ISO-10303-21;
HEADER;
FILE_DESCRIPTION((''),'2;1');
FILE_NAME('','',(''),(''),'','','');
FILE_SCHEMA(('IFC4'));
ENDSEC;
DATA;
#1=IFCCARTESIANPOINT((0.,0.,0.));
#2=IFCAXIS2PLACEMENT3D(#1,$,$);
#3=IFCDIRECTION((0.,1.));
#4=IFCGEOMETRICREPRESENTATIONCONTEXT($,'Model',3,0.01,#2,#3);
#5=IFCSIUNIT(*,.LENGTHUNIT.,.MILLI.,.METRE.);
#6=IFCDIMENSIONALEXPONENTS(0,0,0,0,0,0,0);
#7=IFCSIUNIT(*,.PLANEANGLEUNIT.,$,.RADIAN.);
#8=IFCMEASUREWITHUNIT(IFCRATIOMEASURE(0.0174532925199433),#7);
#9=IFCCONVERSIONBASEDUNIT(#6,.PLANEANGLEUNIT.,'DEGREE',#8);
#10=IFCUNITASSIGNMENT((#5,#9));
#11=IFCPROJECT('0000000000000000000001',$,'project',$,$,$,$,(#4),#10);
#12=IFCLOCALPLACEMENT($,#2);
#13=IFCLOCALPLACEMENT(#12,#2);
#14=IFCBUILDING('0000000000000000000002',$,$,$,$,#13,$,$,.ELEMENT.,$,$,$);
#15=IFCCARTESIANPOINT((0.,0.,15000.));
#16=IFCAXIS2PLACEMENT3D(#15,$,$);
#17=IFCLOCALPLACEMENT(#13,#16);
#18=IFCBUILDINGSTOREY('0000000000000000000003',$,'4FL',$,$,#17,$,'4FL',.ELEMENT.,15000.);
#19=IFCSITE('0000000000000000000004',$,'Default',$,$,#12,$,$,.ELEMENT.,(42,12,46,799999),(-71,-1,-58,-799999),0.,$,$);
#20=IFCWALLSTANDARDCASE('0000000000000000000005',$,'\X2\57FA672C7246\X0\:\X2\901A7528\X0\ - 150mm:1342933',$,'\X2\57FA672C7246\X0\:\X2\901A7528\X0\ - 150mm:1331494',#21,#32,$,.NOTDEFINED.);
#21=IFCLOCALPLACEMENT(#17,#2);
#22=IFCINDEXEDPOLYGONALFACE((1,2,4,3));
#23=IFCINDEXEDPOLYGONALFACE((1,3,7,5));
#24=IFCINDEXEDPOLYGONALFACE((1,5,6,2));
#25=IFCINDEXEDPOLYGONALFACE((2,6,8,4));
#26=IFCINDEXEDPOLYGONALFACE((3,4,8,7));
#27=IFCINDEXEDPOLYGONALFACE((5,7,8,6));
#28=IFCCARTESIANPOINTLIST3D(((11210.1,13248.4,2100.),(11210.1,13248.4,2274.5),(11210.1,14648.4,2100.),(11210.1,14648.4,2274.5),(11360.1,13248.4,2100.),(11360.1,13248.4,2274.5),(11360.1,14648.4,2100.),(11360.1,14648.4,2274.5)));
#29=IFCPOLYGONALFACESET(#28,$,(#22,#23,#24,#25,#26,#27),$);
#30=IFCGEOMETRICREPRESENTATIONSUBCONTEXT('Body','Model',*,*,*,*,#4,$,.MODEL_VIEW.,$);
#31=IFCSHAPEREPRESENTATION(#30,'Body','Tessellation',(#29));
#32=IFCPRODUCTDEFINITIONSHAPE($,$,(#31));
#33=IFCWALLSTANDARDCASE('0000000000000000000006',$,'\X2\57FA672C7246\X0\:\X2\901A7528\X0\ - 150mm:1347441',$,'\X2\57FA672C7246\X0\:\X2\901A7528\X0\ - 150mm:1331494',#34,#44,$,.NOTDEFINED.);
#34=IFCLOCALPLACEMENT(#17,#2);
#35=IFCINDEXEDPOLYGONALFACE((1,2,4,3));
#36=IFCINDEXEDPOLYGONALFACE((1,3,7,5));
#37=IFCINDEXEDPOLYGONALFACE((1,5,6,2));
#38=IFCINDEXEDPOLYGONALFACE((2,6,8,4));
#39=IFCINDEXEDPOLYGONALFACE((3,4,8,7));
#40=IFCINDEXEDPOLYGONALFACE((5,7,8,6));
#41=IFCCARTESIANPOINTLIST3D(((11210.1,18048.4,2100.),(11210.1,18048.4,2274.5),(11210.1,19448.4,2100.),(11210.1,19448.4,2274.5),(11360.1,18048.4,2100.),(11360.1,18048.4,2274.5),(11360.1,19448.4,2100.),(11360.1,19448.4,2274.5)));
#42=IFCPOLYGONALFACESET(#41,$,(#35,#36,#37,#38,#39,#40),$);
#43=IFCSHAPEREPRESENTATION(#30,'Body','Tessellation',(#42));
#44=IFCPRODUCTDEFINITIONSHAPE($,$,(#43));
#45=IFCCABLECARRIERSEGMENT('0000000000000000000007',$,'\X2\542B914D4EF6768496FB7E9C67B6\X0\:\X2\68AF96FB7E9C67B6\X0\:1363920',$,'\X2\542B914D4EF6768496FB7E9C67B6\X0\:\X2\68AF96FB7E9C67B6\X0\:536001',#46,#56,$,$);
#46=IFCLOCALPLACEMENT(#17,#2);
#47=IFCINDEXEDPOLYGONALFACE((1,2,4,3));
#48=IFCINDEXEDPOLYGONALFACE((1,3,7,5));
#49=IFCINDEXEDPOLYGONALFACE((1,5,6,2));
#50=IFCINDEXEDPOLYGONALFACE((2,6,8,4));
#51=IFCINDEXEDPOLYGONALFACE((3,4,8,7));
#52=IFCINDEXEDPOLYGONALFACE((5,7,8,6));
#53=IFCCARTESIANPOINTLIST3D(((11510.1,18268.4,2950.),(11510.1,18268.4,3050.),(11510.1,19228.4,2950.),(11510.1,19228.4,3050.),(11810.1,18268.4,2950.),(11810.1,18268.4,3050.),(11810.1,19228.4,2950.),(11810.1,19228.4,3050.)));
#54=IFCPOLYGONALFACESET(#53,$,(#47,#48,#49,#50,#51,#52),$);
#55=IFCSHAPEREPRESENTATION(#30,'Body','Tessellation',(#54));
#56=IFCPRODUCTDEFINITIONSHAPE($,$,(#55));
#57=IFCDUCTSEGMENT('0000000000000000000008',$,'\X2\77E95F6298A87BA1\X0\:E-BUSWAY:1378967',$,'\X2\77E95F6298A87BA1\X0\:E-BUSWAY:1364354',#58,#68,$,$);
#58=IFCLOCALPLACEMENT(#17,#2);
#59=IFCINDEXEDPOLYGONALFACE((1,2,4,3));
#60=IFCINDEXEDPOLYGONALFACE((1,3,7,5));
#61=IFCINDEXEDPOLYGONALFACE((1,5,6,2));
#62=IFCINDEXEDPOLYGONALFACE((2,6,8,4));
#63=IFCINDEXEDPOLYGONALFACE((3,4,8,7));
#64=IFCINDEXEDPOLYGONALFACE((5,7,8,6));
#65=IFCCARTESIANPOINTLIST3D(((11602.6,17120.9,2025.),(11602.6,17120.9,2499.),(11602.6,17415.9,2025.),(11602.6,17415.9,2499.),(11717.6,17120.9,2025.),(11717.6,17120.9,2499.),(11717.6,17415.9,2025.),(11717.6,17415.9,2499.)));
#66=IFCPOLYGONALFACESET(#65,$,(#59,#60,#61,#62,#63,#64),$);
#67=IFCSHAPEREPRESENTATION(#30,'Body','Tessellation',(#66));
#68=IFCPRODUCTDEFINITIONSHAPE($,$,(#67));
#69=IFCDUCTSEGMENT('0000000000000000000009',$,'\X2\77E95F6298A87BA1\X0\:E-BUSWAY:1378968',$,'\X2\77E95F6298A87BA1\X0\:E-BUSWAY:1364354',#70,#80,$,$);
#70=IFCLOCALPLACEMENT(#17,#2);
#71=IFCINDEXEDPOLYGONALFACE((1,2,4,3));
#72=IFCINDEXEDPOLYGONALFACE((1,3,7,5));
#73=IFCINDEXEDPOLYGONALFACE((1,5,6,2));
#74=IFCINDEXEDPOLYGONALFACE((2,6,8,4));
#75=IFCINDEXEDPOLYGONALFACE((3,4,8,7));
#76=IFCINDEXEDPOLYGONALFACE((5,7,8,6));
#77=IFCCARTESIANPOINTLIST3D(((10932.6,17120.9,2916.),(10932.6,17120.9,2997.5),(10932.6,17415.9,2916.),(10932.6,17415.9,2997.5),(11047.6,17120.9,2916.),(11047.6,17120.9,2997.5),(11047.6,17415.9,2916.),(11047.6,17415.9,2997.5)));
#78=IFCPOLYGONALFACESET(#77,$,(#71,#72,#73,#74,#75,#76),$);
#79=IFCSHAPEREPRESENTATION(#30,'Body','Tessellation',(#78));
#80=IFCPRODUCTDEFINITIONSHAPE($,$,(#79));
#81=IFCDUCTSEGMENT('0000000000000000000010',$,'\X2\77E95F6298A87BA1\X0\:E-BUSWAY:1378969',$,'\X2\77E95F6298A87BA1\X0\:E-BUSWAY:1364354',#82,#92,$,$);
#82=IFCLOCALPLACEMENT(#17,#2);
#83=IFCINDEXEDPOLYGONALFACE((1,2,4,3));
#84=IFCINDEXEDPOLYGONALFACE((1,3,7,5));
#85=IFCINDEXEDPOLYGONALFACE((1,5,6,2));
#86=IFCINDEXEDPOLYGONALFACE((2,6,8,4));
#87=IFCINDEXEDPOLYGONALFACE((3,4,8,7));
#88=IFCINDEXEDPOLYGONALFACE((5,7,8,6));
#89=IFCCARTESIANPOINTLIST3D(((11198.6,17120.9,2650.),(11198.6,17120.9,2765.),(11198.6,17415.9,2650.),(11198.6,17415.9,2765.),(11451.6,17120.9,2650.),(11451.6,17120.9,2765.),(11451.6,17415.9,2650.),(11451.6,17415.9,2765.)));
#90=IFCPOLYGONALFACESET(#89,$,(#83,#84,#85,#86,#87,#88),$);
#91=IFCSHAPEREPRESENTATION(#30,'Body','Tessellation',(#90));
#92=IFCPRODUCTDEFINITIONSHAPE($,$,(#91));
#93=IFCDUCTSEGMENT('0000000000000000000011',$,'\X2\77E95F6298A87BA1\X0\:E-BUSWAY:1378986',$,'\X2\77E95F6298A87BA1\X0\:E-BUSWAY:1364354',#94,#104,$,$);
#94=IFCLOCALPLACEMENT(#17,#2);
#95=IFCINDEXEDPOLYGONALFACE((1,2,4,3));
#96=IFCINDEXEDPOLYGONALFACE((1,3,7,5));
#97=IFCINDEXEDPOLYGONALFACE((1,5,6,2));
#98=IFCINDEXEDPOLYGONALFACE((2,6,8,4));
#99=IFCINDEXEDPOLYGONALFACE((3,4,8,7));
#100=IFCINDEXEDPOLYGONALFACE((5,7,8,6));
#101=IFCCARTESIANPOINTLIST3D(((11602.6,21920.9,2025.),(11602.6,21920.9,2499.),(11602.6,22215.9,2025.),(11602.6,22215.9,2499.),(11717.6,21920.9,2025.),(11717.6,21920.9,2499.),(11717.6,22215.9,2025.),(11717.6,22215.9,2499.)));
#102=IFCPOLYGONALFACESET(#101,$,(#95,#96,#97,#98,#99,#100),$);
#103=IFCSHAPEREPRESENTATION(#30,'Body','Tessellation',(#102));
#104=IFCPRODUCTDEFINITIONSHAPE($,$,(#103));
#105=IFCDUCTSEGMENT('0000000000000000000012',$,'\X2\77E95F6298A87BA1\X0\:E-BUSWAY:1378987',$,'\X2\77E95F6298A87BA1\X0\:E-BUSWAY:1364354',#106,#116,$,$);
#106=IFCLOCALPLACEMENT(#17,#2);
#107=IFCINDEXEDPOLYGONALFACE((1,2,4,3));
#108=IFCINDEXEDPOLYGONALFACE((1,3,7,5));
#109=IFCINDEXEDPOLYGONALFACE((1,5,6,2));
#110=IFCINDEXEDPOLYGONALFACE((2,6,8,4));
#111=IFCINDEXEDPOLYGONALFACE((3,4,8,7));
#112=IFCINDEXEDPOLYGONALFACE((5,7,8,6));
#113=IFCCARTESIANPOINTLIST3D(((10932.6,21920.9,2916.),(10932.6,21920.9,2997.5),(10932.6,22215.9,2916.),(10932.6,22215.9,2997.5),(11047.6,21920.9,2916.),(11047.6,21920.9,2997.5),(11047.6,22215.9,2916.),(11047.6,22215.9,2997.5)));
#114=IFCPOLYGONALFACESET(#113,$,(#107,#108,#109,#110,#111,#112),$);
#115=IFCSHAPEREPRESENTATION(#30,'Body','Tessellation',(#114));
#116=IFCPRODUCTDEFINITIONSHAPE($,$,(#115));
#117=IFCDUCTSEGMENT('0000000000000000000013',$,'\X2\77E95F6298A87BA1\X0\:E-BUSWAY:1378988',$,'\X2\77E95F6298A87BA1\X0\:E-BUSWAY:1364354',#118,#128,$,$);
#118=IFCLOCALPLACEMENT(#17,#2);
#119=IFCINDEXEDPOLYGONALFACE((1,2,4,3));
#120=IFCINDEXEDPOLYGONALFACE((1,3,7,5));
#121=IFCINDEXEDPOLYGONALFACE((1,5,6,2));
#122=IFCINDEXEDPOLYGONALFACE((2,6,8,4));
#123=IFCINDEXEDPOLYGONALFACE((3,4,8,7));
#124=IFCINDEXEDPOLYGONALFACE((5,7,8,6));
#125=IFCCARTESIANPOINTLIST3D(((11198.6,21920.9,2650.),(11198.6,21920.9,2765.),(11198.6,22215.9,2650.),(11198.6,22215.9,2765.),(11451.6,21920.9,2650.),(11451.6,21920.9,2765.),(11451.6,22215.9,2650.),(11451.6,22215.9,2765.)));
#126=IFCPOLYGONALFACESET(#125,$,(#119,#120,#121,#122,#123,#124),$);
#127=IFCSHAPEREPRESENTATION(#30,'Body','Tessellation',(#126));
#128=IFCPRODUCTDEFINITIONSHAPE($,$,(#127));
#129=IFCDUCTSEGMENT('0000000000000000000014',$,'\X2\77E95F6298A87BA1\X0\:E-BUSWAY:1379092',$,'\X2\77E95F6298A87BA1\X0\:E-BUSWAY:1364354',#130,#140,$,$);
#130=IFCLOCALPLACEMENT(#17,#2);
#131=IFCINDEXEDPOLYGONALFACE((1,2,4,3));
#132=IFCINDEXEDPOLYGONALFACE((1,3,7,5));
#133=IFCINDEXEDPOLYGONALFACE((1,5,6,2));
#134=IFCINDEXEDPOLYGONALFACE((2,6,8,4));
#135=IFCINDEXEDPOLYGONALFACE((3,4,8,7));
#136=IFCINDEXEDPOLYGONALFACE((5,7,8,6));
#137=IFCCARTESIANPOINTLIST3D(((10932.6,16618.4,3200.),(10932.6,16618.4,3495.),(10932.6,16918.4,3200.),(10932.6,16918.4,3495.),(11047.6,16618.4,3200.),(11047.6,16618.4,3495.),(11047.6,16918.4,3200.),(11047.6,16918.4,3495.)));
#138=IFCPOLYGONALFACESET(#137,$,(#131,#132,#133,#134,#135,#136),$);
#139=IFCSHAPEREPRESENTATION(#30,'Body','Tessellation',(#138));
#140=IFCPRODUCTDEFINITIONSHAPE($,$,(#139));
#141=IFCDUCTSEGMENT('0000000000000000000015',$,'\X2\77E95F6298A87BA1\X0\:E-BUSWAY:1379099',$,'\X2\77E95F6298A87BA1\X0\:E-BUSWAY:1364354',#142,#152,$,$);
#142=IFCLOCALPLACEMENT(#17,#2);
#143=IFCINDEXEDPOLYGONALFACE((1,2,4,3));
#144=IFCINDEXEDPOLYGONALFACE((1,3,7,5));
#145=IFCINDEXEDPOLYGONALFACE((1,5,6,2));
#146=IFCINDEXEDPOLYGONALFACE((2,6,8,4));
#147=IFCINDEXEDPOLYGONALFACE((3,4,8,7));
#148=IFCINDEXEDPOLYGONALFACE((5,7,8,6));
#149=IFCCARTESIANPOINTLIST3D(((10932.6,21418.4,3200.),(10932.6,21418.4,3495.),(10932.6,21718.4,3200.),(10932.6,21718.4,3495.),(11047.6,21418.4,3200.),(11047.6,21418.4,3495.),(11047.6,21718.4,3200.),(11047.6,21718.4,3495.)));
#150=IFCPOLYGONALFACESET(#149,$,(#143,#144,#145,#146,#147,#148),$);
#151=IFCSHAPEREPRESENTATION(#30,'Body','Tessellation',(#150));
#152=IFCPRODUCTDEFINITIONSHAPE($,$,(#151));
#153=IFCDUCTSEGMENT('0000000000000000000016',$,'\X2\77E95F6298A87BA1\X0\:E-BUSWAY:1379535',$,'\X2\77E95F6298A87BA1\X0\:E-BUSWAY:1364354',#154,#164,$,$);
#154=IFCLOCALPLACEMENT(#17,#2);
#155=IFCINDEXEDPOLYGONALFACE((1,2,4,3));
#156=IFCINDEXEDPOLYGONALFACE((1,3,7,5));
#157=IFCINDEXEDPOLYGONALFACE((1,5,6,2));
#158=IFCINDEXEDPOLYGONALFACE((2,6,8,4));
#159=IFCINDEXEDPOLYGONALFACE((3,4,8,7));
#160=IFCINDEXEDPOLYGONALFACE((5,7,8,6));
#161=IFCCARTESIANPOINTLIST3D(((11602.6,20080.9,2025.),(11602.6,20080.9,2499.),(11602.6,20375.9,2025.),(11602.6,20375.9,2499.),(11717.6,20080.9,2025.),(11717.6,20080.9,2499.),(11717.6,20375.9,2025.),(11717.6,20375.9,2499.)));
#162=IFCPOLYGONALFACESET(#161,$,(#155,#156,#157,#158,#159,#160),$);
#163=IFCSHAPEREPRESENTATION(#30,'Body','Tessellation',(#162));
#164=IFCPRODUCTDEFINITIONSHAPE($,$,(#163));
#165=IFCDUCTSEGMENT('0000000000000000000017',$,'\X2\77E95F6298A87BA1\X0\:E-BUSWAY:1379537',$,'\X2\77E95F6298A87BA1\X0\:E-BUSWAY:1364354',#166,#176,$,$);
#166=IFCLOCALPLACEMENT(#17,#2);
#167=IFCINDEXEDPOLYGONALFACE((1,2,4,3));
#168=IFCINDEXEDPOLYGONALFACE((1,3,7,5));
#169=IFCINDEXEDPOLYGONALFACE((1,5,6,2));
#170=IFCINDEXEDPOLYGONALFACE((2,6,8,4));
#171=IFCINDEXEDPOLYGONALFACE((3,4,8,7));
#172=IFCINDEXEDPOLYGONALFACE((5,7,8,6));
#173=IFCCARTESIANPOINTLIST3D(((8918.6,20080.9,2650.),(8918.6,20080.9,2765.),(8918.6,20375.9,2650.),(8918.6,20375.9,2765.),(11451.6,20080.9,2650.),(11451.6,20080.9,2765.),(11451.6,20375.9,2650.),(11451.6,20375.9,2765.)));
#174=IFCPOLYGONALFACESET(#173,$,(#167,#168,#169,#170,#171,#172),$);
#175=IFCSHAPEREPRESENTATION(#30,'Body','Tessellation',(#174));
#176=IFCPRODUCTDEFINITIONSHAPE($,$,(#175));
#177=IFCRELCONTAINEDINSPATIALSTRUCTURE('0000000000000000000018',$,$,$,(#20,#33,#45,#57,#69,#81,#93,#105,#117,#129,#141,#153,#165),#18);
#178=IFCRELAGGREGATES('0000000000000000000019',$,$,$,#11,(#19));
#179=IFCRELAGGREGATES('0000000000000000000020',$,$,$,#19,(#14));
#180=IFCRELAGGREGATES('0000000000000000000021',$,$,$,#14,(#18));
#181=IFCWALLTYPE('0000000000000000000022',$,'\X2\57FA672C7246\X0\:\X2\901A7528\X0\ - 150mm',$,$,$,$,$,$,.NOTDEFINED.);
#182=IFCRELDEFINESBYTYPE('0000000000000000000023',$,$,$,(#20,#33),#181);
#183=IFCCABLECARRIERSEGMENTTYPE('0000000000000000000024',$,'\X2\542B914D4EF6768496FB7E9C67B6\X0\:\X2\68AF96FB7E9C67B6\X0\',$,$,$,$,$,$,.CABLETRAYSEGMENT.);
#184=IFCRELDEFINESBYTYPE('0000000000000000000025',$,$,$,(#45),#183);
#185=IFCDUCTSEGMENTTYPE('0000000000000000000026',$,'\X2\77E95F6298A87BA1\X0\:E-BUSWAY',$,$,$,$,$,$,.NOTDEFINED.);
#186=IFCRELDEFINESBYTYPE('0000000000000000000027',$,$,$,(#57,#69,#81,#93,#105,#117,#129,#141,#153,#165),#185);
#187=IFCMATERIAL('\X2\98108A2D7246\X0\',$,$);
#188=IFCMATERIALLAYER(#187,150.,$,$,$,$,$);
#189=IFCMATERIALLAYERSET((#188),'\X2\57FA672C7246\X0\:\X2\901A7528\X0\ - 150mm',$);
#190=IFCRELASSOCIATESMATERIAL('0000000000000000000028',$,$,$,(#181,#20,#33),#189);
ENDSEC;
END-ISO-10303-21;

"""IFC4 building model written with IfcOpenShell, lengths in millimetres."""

from ifc_helpers import new_model, entity, si_unit, converted_unit, direction, frame, frame_2d, origin, origin_2d_with_axis, place, context, subcontext, project, spatial, rectangle, extrude, material, layer, layer_set, layer_usage, type_object, element, save


model = new_model("IFC4")

# Units and contexts
model_context = context("Model", 3, precision=0.01, world=origin(), true_north=direction((0.0, 1.0)))
body_context = subcontext(model_context, "Body", "Model", "MODEL_VIEW")
ifc_project = project(units=[si_unit("LENGTHUNIT", "METRE", prefix="MILLI"), converted_unit("PLANEANGLEUNIT", "DEGREE", entity("IfcRatioMeasure", 0.0174532925199433), si_unit("PLANEANGLEUNIT", "RADIAN"), dimensions=[0, 0, 0, 0, 0, 0, 0])], contexts=[model_context])

# Site, building, storey
site_placement = place(None, origin())
site = spatial("IfcSite", under=ifc_project, at=site_placement, Name="Default", CompositionType="ELEMENT", RefLatitude=(42, 12, 46, 799999), RefLongitude=(-71, -1, -58, -799999), RefElevation=0.0)
building_placement = place(site_placement, origin())
building = spatial("IfcBuilding", under=site, at=building_placement, CompositionType="ELEMENT")
storey_placement = place(building_placement, frame((0.0, 0.0, 15000.0)))
storey = spatial("IfcBuildingStorey", under=building, at=storey_placement, Name="4FL", LongName="4FL", CompositionType="ELEMENT", Elevation=15000.0)

# Walls, openings
ifc_material = material(Name="預設牆")
ifc_layer = layer(ifc_material, 150.0)
ifc_layer_set = layer_set([ifc_layer], Name="基本牆:通用 - 150mm")
ifc_layer_usage_1 = layer_usage(ifc_layer_set, "AXIS2", "NEGATIVE", 75.0)
wall_type = type_object("IfcWallType", Name="基本牆:通用 - 150mm", PredefinedType="NOTDEFINED", material=ifc_layer_set)
wall_1_placement = place(storey_placement, frame((11285.1, 14648.4, 2100.0), z_axis=(0.0, 0.0, 1.0), x_axis=(0.0, -1.0, 0.0)))
wall_1 = element("IfcWallStandardCase", 1, at=wall_1_placement, inside=storey, type_object=wall_type, material=ifc_layer_usage_1, Name="基本牆:通用 - 150mm:1342933", ObjectType="基本牆:通用 - 150mm:1331494", PredefinedType="NOTDEFINED", context=body_context, shape_type="SweptSolid", body=[
    extrude(rectangle(XDim=1400.0, YDim=150.0, at=frame_2d((700.0, 0.0), x_axis=(-1.0, 0.0))), origin(), (0.0, 0.0, 1.0), 174.4),
])
opening_1_placement = place(wall_1_placement, frame((1400.0, 75.0, -2100.0)))
element("IfcOpeningElement", 2, at=opening_1_placement, cuts=wall_1, ObjectType="Opening", PredefinedType="OPENING", context=body_context, shape_type="SweptSolid", body=[
    extrude(rectangle(XDim=2100.0, YDim=1400.0, at=frame_2d((1050.0, 700.0), x_axis=(1.0, 0.0))), frame((0.0, 0.0, 0.0), z_axis=(0.0, -1.0, 0.0), x_axis=(0.0, 0.0, 1.0)), (0.0, 0.0, 1.0), 150.0),
])
ifc_layer_usage_2 = layer_usage(ifc_layer_set, "AXIS2", "NEGATIVE", 75.0)
wall_2_placement = place(storey_placement, frame((11285.1, 19448.4, 2100.0), z_axis=(0.0, 0.0, 1.0), x_axis=(0.0, -1.0, 0.0)))
wall_2 = element("IfcWallStandardCase", 3, at=wall_2_placement, inside=storey, type_object=wall_type, material=ifc_layer_usage_2, Name="基本牆:通用 - 150mm:1347441", ObjectType="基本牆:通用 - 150mm:1331494", PredefinedType="NOTDEFINED", context=body_context, shape_type="SweptSolid", body=[
    extrude(rectangle(XDim=1400.0, YDim=150.0, at=frame_2d((700.0, 0.0), x_axis=(-1.0, 0.0))), origin(), (0.0, 0.0, 1.0), 174.4),
])
opening_2_placement = place(wall_2_placement, frame((1400.0, 75.0, -2100.0)))
element("IfcOpeningElement", 4, at=opening_2_placement, cuts=wall_2, ObjectType="Opening", PredefinedType="OPENING", context=body_context, shape_type="SweptSolid", body=[
    extrude(rectangle(XDim=2100.0, YDim=1400.0, at=frame_2d((1050.0, 700.0), x_axis=(1.0, 0.0))), frame((0.0, 0.0, 0.0), z_axis=(0.0, -1.0, 0.0), x_axis=(0.0, 0.0, 1.0)), (0.0, 0.0, 1.0), 150.0),
])

# Cable carrier segment
cable_carrier_segment_type = type_object("IfcCableCarrierSegmentType", Name="含配件的電纜架:梯電纜架", PredefinedType="CABLETRAYSEGMENT")
cable_carrier_segment_placement = place(storey_placement, frame((11510.1, 18268.4, 2950.0)))
element("IfcCableCarrierSegment", 5, at=cable_carrier_segment_placement, inside=storey, type_object=cable_carrier_segment_type, Name="含配件的電纜架:梯電纜架:1363920", ObjectType="含配件的電纜架:梯電纜架:536001", context=body_context, shape_type="SweptSolid", body=[
    extrude(rectangle(XDim=960.0, YDim=300.0, at=origin_2d_with_axis()), frame((150.0, 480.0, 0.0), z_axis=(0.0, 0.0, 1.0), x_axis=(0.0, -1.0, 0.0)), (0.0, 0.0, 1.0), 100.0),
])

# Duct segments
duct_segment_type = type_object("IfcDuctSegmentType", Name="矩形風管:E-BUSWAY", PredefinedType="NOTDEFINED")
duct_segment_1_placement = place(storey_placement, frame((11602.6, 17120.9, 2025.0)))
element("IfcDuctSegment", 6, at=duct_segment_1_placement, inside=storey, type_object=duct_segment_type, Name="矩形風管:E-BUSWAY:1378967", ObjectType="矩形風管:E-BUSWAY:1364354", context=body_context, shape_type="SweptSolid", body=[
    extrude(rectangle(XDim=115.0, YDim=295.0, at=origin_2d_with_axis()), frame((57.5, 147.5, 0.0), z_axis=(0.0, 0.0, 1.0), x_axis=(-1.0, 0.0, 0.0)), (0.0, 0.0, 1.0), 474.0),
])
duct_segment_2_placement = place(storey_placement, frame((10932.6, 17120.9, 2916.0)))
element("IfcDuctSegment", 7, at=duct_segment_2_placement, inside=storey, type_object=duct_segment_type, Name="矩形風管:E-BUSWAY:1378968", ObjectType="矩形風管:E-BUSWAY:1364354", context=body_context, shape_type="SweptSolid", body=[
    extrude(rectangle(XDim=115.0, YDim=295.0, at=frame_2d((0.0, 0.0), x_axis=(1.0, 0.0))), frame((57.5, 147.5, 0.0), z_axis=(0.0, 0.0, 1.0), x_axis=(-1.0, 0.0, 0.0)), (0.0, 0.0, 1.0), 81.5),
])
duct_segment_3_placement = place(storey_placement, frame((11198.6, 17120.9, 2650.0)))
element("IfcDuctSegment", 8, at=duct_segment_3_placement, inside=storey, type_object=duct_segment_type, Name="矩形風管:E-BUSWAY:1378969", ObjectType="矩形風管:E-BUSWAY:1364354", context=body_context, shape_type="SweptSolid", body=[
    extrude(rectangle(XDim=253.0, YDim=295.0, at=frame_2d((0.0, 0.0), x_axis=(1.0, 0.0))), frame((126.5, 147.5, 0.0)), (0.0, 0.0, 1.0), 115.0),
])
duct_segment_4_placement = place(storey_placement, frame((11602.6, 21920.9, 2025.0)))
element("IfcDuctSegment", 9, at=duct_segment_4_placement, inside=storey, type_object=duct_segment_type, Name="矩形風管:E-BUSWAY:1378986", ObjectType="矩形風管:E-BUSWAY:1364354", context=body_context, shape_type="SweptSolid", body=[
    extrude(rectangle(XDim=115.0, YDim=295.0, at=origin_2d_with_axis()), frame((57.5, 147.5, 0.0), z_axis=(0.0, 0.0, 1.0), x_axis=(-1.0, 0.0, 0.0)), (0.0, 0.0, 1.0), 474.0),
])
duct_segment_5_placement = place(storey_placement, frame((10932.6, 21920.9, 2916.0)))
element("IfcDuctSegment", 10, at=duct_segment_5_placement, inside=storey, type_object=duct_segment_type, Name="矩形風管:E-BUSWAY:1378987", ObjectType="矩形風管:E-BUSWAY:1364354", context=body_context, shape_type="SweptSolid", body=[
    extrude(rectangle(XDim=115.0, YDim=295.0, at=frame_2d((0.0, 0.0), x_axis=(1.0, 0.0))), frame((57.5, 147.5, 0.0), z_axis=(0.0, 0.0, 1.0), x_axis=(-1.0, 0.0, 0.0)), (0.0, 0.0, 1.0), 81.5),
])
duct_segment_6_placement = place(storey_placement, frame((11198.6, 21920.9, 2650.0)))
element("IfcDuctSegment", 11, at=duct_segment_6_placement, inside=storey, type_object=duct_segment_type, Name="矩形風管:E-BUSWAY:1378988", ObjectType="矩形風管:E-BUSWAY:1364354", context=body_context, shape_type="SweptSolid", body=[
    extrude(rectangle(XDim=253.0, YDim=295.0, at=frame_2d((0.0, 0.0), x_axis=(1.0, 0.0))), frame((126.5, 147.5, 0.0)), (0.0, 0.0, 1.0), 115.0),
])
duct_segment_7_placement = place(storey_placement, frame((10932.6, 16618.4, 3200.0)))
element("IfcDuctSegment", 12, at=duct_segment_7_placement, inside=storey, type_object=duct_segment_type, Name="矩形風管:E-BUSWAY:1379092", ObjectType="矩形風管:E-BUSWAY:1364354", context=body_context, shape_type="SweptSolid", body=[
    extrude(rectangle(XDim=300.0, YDim=115.0, at=frame_2d((0.0, 0.0), x_axis=(1.0, 0.0))), frame((57.5, 150.0, 0.0), z_axis=(0.0, 0.0, 1.0), x_axis=(0.0, 1.0, 0.0)), (0.0, 0.0, 1.0), 295.0),
])
duct_segment_8_placement = place(storey_placement, frame((10932.6, 21418.4, 3200.0)))
element("IfcDuctSegment", 13, at=duct_segment_8_placement, inside=storey, type_object=duct_segment_type, Name="矩形風管:E-BUSWAY:1379099", ObjectType="矩形風管:E-BUSWAY:1364354", context=body_context, shape_type="SweptSolid", body=[
    extrude(rectangle(XDim=300.0, YDim=115.0, at=origin_2d_with_axis()), frame((57.5, 150.0, 0.0), z_axis=(0.0, 0.0, 1.0), x_axis=(0.0, 1.0, 0.0)), (0.0, 0.0, 1.0), 295.0),
])
duct_segment_9_placement = place(storey_placement, frame((11602.6, 20080.9, 2025.0)))
element("IfcDuctSegment", 14, at=duct_segment_9_placement, inside=storey, type_object=duct_segment_type, Name="矩形風管:E-BUSWAY:1379535", ObjectType="矩形風管:E-BUSWAY:1364354", context=body_context, shape_type="SweptSolid", body=[
    extrude(rectangle(XDim=115.0, YDim=295.0, at=origin_2d_with_axis()), frame((57.5, 147.5, 0.0), z_axis=(0.0, 0.0, 1.0), x_axis=(-1.0, 0.0, 0.0)), (0.0, 0.0, 1.0), 474.0),
])
duct_segment_10_placement = place(storey_placement, frame((8918.6, 20080.9, 2650.0)))
element("IfcDuctSegment", 15, at=duct_segment_10_placement, inside=storey, type_object=duct_segment_type, Name="矩形風管:E-BUSWAY:1379537", ObjectType="矩形風管:E-BUSWAY:1364354", context=body_context, shape_type="SweptSolid", body=[
    extrude(rectangle(XDim=2533.0, YDim=295.0, at=origin_2d_with_axis()), frame((1266.5, 147.5, 0.0)), (0.0, 0.0, 1.0), 115.0),
])

save(model, "model.ifc")
